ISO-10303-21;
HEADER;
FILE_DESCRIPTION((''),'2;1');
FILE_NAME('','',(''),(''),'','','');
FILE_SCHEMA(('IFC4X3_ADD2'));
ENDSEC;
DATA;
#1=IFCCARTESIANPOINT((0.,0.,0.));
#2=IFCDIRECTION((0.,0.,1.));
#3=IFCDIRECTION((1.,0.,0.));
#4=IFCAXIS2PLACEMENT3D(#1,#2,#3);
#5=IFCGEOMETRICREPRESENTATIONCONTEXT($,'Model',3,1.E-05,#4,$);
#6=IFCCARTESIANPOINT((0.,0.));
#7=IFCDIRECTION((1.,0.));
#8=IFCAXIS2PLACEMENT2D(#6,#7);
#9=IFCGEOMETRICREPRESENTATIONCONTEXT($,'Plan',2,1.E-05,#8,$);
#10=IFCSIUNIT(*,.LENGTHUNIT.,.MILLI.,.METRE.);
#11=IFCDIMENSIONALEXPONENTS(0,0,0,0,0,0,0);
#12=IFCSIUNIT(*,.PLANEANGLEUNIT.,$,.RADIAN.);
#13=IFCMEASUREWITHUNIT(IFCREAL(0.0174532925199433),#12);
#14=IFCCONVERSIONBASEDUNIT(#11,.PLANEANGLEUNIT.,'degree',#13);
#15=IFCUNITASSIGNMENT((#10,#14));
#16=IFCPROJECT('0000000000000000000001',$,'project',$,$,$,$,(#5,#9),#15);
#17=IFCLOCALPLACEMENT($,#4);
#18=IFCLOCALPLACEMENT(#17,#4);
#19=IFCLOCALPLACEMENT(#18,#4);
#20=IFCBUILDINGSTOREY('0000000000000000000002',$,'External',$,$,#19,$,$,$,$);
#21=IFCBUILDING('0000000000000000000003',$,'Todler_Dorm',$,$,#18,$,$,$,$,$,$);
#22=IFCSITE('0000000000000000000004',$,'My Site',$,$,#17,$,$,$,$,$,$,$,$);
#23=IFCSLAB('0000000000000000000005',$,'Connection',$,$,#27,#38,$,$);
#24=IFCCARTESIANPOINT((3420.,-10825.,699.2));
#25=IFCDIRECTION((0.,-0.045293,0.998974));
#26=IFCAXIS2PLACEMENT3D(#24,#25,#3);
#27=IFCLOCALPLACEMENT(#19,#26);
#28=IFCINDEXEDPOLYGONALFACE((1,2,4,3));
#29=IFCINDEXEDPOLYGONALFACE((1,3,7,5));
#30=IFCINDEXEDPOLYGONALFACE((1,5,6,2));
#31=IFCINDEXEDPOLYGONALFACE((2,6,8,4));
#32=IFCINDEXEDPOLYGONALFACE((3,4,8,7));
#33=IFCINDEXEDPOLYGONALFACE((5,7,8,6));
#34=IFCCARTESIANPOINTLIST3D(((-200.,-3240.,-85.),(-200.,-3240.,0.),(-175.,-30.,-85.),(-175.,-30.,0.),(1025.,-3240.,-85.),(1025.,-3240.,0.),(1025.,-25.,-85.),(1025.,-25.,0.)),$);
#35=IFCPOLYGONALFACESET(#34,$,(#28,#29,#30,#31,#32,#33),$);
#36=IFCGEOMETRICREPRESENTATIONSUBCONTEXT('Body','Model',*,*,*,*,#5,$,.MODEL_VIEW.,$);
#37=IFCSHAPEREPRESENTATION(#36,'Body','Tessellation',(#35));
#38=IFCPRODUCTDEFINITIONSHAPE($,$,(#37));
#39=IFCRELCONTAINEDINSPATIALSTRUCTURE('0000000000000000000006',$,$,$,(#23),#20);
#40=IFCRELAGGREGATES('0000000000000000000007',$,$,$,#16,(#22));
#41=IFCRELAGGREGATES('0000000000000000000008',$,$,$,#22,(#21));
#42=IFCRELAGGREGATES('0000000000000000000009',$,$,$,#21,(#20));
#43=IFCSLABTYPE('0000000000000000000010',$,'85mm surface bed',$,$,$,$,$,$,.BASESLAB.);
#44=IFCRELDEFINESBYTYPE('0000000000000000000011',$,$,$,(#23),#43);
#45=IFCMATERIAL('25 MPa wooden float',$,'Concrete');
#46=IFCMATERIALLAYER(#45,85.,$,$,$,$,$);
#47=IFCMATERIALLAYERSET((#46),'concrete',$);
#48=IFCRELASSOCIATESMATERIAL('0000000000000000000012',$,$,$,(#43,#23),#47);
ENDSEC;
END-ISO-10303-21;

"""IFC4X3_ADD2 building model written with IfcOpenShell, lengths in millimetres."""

from ifc_helpers import new_model, entity, si_unit, converted_unit, frame, origin_with_axes, origin_2d_with_axis, place, context, subcontext, project, spatial, indexed_curve, outline, extrude, material, layer, layer_set, layer_usage, type_object, element, save


model = new_model("IFC4X3_ADD2")

# Units and contexts
model_context = context("Model", 3, precision=1e-05, world=origin_with_axes())
plan_context = context("Plan", 2, precision=1e-05, world=origin_2d_with_axis())
body_context_1 = subcontext(model_context, "Body", "Model", "MODEL_VIEW")
ifc_project = project(units=[si_unit("LENGTHUNIT", "METRE", prefix="MILLI"), converted_unit("PLANEANGLEUNIT", "degree", entity("IfcReal", 0.0174532925199433), si_unit("PLANEANGLEUNIT", "RADIAN"), dimensions=[0, 0, 0, 0, 0, 0, 0])], contexts=[model_context, plan_context])

# Site, building, storey
site_placement = place(None, origin_with_axes())
site = spatial("IfcSite", under=ifc_project, at=site_placement, Name="My Site")
building_placement = place(site_placement, origin_with_axes())
building = spatial("IfcBuilding", under=site, at=building_placement, Name="Todler_Dorm")
storey_placement = place(building_placement, origin_with_axes())
storey = spatial("IfcBuildingStorey", under=building, at=storey_placement, Name="External")

# Slab
ifc_material_1 = material(Name="25 MPa wooden float", Category="Concrete")
ifc_layer_1 = layer(ifc_material_1, 85.0)
ifc_layer_set_1 = layer_set([ifc_layer_1], Name="concrete")
ifc_layer_usage_1 = layer_usage(ifc_layer_set_1, "AXIS3", "POSITIVE", -85.0)
slab_type = type_object("IfcSlabType", Name="85mm surface bed", PredefinedType="BASESLAB", material=ifc_layer_set_1)
slab_placement = place(storey_placement, frame((3420.0, -10825.0, 699.2), z_axis=(0.0, -0.045293, 0.998974), x_axis=(1.0, 0.0, 0.0)))
element("IfcSlab", 1, at=slab_placement, inside=storey, type_object=slab_type, material=ifc_layer_usage_1, Name="Connection", context=body_context_1, shape_type="SweptSolid", body=[
    extrude(outline(indexed_curve([(-175.0, -30.0), (-200.0, -3240.0), (1025.0, -3240.0), (1025.0, -25.0), (-175.0, -30.0)])), frame((0.0, 0.0, -85.0), z_axis=(0.0, 0.0, 1.0), x_axis=(1.0, 0.0, 0.0)), (0.0, 0.0, 1.0), 85.0),
])

save(model, "model.ifc")
